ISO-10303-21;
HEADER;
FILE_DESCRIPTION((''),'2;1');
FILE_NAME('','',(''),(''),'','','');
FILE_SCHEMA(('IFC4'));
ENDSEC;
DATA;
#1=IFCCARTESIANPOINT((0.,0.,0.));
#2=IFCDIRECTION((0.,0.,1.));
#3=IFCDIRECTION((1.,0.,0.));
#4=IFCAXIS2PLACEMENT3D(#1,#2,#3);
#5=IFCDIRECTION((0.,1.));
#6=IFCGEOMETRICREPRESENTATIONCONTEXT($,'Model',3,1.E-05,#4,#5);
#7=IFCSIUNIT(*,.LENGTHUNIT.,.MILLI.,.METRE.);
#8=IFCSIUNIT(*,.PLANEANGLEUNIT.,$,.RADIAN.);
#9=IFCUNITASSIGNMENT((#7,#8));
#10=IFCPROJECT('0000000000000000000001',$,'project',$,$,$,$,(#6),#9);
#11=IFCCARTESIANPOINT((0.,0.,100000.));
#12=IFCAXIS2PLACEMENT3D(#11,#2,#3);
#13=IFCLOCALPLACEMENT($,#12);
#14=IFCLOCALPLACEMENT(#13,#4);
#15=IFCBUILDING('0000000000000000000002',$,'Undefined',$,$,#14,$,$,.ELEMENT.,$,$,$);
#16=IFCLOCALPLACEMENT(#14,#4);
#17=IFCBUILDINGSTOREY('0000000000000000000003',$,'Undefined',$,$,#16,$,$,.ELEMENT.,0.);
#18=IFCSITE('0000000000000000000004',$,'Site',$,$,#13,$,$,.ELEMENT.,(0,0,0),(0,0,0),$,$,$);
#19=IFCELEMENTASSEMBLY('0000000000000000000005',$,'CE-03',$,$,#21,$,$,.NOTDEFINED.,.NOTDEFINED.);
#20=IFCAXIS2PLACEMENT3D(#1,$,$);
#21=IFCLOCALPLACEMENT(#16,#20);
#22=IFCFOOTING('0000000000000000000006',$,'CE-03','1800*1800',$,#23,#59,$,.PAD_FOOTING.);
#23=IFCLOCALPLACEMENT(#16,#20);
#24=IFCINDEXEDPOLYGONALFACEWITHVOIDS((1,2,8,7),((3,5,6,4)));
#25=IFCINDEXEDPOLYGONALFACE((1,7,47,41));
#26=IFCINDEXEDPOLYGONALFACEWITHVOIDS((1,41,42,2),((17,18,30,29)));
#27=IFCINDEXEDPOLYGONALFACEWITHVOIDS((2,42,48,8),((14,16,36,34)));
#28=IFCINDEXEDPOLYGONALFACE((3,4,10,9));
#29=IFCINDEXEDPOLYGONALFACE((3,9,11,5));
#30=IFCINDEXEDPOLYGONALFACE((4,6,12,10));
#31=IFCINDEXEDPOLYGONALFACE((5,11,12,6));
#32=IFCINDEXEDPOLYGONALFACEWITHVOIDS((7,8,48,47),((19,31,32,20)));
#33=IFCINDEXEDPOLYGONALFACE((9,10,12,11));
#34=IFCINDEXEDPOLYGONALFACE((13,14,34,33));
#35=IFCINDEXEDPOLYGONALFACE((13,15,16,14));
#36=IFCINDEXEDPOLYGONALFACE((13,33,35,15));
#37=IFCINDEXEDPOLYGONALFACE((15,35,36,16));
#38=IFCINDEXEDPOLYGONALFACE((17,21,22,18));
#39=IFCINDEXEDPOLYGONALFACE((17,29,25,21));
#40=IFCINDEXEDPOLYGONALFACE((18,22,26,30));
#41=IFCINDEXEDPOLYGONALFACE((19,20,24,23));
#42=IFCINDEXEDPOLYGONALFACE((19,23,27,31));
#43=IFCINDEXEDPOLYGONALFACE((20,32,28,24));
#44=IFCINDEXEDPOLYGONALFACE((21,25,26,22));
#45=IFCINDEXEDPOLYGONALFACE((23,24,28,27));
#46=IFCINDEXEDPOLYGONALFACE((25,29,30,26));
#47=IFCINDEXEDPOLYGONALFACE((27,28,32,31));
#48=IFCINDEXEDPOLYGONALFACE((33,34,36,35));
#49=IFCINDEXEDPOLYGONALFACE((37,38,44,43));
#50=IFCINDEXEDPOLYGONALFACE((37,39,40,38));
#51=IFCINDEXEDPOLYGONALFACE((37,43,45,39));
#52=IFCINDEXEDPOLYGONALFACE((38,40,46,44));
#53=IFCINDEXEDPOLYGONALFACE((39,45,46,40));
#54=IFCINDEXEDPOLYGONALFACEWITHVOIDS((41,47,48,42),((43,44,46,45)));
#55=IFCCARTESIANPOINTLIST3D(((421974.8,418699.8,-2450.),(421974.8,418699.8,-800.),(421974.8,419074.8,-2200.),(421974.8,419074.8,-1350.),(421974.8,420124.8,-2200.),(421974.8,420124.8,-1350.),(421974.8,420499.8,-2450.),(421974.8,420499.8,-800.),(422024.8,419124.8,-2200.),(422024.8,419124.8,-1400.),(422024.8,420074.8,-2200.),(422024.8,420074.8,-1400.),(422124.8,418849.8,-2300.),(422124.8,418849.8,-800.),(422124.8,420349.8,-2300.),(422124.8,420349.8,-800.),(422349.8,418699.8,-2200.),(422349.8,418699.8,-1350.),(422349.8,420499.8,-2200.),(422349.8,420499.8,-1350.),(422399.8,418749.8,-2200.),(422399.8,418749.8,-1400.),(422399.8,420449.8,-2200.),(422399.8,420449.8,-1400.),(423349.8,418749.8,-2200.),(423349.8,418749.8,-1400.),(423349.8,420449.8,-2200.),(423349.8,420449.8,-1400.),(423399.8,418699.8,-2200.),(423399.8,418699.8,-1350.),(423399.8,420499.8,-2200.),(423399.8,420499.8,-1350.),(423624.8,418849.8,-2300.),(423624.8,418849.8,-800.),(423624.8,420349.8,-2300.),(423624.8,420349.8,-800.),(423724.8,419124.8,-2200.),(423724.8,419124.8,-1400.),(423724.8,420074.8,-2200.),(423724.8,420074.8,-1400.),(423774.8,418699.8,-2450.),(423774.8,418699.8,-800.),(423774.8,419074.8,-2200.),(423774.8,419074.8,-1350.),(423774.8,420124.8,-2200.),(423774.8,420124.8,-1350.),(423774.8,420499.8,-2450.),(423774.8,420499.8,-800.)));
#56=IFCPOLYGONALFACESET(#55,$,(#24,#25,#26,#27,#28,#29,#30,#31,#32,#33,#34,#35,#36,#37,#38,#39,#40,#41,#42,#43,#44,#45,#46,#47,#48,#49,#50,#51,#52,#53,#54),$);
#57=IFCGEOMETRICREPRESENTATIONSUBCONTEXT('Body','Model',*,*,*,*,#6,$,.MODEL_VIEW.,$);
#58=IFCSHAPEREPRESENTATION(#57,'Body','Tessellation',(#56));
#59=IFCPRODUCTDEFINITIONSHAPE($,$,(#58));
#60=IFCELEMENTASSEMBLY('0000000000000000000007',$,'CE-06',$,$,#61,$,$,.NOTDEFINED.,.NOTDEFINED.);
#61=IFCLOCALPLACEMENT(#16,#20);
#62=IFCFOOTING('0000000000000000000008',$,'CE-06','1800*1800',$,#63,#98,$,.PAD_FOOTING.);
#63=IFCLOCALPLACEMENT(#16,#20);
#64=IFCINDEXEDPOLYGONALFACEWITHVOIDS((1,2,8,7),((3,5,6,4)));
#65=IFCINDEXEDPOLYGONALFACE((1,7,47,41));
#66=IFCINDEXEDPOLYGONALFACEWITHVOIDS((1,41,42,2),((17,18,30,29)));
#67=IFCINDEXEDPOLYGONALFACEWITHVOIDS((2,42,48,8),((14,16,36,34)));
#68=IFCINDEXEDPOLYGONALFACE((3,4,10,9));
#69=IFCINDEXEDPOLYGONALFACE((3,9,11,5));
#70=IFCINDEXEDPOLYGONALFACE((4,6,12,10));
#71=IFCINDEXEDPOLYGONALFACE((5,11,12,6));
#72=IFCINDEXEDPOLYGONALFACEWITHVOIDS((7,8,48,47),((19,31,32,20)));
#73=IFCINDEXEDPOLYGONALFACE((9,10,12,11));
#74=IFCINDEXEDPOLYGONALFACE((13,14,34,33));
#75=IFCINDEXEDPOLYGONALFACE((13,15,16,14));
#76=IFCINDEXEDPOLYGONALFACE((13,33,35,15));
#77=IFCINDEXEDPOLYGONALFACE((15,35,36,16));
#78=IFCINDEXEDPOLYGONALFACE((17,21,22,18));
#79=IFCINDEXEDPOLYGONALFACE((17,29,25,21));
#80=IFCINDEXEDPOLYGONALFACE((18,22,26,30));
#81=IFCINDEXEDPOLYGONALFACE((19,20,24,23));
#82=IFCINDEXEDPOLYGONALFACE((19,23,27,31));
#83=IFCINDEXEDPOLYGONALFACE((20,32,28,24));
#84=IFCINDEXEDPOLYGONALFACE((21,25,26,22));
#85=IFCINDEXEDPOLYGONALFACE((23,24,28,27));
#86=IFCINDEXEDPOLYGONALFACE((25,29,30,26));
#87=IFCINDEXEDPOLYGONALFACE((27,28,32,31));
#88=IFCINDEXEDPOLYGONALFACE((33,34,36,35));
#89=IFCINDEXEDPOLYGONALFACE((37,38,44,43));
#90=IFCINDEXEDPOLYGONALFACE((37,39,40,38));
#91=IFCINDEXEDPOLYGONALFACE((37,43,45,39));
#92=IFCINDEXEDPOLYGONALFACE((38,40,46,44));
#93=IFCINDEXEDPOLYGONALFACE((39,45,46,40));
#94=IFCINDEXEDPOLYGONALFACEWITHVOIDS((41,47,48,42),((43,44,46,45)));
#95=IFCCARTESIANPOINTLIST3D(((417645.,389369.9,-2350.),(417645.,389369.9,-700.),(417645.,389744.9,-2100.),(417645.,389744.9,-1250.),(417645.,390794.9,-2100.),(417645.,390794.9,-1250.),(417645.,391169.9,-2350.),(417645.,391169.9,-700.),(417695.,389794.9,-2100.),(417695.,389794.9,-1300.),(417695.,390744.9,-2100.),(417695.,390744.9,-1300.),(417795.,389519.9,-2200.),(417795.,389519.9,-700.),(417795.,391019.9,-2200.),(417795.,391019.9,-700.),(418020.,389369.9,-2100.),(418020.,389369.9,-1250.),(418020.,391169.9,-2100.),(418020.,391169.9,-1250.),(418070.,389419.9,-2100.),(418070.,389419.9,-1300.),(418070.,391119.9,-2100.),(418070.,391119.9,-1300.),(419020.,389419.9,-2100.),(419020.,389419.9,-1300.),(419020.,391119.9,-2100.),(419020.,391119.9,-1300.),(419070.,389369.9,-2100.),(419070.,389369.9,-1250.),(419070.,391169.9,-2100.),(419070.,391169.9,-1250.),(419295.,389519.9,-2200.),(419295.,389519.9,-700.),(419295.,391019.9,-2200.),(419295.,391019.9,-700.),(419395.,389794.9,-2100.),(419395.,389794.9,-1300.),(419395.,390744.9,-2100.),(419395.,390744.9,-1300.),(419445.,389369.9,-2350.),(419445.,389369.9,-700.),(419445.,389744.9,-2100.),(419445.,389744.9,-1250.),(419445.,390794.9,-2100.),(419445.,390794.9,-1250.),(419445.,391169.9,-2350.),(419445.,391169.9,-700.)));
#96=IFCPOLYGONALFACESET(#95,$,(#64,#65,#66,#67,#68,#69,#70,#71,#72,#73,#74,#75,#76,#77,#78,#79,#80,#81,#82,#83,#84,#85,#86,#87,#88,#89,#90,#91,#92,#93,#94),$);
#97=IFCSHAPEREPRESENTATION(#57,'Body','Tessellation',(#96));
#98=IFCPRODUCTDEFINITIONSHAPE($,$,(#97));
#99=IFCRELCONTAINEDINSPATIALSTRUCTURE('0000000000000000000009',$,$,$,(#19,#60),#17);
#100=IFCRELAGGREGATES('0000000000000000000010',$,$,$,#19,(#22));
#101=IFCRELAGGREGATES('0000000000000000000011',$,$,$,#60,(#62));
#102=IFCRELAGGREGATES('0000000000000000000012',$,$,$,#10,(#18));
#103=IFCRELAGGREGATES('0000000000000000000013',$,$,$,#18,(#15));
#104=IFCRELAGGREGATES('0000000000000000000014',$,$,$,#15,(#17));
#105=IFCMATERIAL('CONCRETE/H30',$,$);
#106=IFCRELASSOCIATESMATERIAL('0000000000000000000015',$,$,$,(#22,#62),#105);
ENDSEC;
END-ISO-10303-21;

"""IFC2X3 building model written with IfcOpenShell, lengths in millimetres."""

from ifc_helpers import new_model, si_unit, direction, frame, origin_with_axes, origin_2d_with_axis, place, context, subcontext, project, spatial, polyline, rectangle, outline, extrude, boolean, material, element, aggregate, save


model = new_model("IFC2X3")

# Units and contexts
model_context = context("Model", 3, precision=1e-05, world=origin_with_axes(), true_north=direction((0.0, 1.0)))
body_context = subcontext(model_context, "Body", "Model", "MODEL_VIEW")
ifc_project = project(units=[si_unit("LENGTHUNIT", "METRE", prefix="MILLI"), si_unit("PLANEANGLEUNIT", "RADIAN")], contexts=[model_context])

# Site, building, storey
site_placement = place(None, frame((0.0, 0.0, 100000.0), z_axis=(0.0, 0.0, 1.0), x_axis=(1.0, 0.0, 0.0)))
site = spatial("IfcSite", under=ifc_project, at=site_placement, Name="Site", CompositionType="ELEMENT", RefLatitude=(0, 0, 0), RefLongitude=(0, 0, 0))
building_placement = place(site_placement, origin_with_axes())
building = spatial("IfcBuilding", under=site, at=building_placement, Name="Undefined", CompositionType="ELEMENT")
storey_placement = place(building_placement, origin_with_axes())
storey = spatial("IfcBuildingStorey", under=building, at=storey_placement, Name="Undefined", CompositionType="ELEMENT", Elevation=0.0)

# Element assemblies, footings
ifc_material_1 = material(Name="CONCRETE/H30")
assembly_1_placement = place(storey_placement, origin_with_axes())
assembly_1 = element("IfcElementAssembly", 1, at=assembly_1_placement, inside=storey, Name="CE-03", AssemblyPlace="NOTDEFINED", PredefinedType="NOTDEFINED")
footing_1_placement = place(assembly_1_placement, frame((422874.8, 419599.8, -2450.0), z_axis=(0.0, 1.0, 0.0), x_axis=(0.0, 0.0, 1.0)))
solid_1 = boolean("DIFFERENCE", boolean("DIFFERENCE", boolean("DIFFERENCE", extrude(outline(polyline([(0.0, 0.0), (1050.0, 0.0), (1050.0, 850.0), (0.0, 850.0), (0.0, 0.0)])), frame((1100.0, 900.0, -525.0), z_axis=(0.0, -1.0, 0.0), x_axis=(0.0, 0.0, 1.0)), (0.0, 0.0, 1.0), 50.0), extrude(outline(polyline([(0.0, 0.0), (70.7, 0.0), (70.7, 850.0), (0.0, 850.0), (0.0, 0.0)])), frame((1100.0, 708.6, -616.4), z_axis=(0.0, 0.707107, 0.707107), x_axis=(0.0, 0.707107, -0.707107)), (0.0, 0.0, 1.0), 200.0)), extrude(outline(polyline([(0.0, 0.0), (70.7, 0.0), (70.7, 850.0), (0.0, 850.0), (0.0, 0.0)])), frame((1100.0, 758.6, 666.4), z_axis=(0.0, 0.707107, -0.707107), x_axis=(0.0, -0.707107, -0.707107)), (0.0, 0.0, 1.0), 200.0)), extrude(outline(polyline([(0.0, 0.0), (70.7, 0.0), (70.7, 1050.0), (0.0, 1050.0), (0.0, 0.0)])), frame((1050.0, 850.0, -525.0), z_axis=(0.707107, -0.707107, 0.0), x_axis=(0.707107, 0.707107, 0.0)), (0.0, 0.0, 1.0), 200.0))
solid_2 = boolean("DIFFERENCE", boolean("DIFFERENCE", boolean("DIFFERENCE", extrude(outline(polyline([(0.0, 0.0), (1050.0, 0.0), (1050.0, 850.0), (0.0, 850.0), (0.0, 0.0)])), frame((1100.0, -525.0, -900.0), z_axis=(0.0, 0.0, 1.0), x_axis=(0.0, 1.0, 0.0)), (0.0, 0.0, 1.0), 50.0), extrude(outline(polyline([(0.0, 0.0), (70.7, 0.0), (70.7, 850.0), (0.0, 850.0), (0.0, 0.0)])), frame((1100.0, -616.4, -708.6), z_axis=(0.0, 0.707107, -0.707107), x_axis=(0.0, -0.707107, -0.707107)), (0.0, 0.0, 1.0), 200.0)), extrude(outline(polyline([(0.0, 0.0), (70.7, 0.0), (70.7, 850.0), (0.0, 850.0), (0.0, 0.0)])), frame((1100.0, 666.4, -758.6), z_axis=(0.0, -0.707107, -0.707107), x_axis=(0.0, -0.707107, 0.707107)), (0.0, 0.0, 1.0), 200.0)), extrude(outline(polyline([(0.0, 0.0), (70.7, 0.0), (70.7, 1050.0), (0.0, 1050.0), (0.0, 0.0)])), frame((1050.0, -525.0, -850.0), z_axis=(0.707107, 0.0, 0.707107), x_axis=(0.707107, 0.0, -0.707107)), (0.0, 0.0, 1.0), 200.0))
solid_3 = boolean("DIFFERENCE", boolean("DIFFERENCE", boolean("DIFFERENCE", extrude(outline(polyline([(0.0, 0.0), (1050.0, 0.0), (1050.0, 850.0), (0.0, 850.0), (0.0, 0.0)])), frame((1100.0, -525.0, 850.0), z_axis=(0.0, 0.0, 1.0), x_axis=(0.0, 1.0, 0.0)), (0.0, 0.0, 1.0), 50.0), extrude(outline(polyline([(0.0, 0.0), (70.7, 0.0), (70.7, 850.0), (0.0, 850.0), (0.0, 0.0)])), frame((1100.0, -475.0, 850.0), z_axis=(0.0, -0.707107, -0.707107), x_axis=(0.0, -0.707107, 0.707107)), (0.0, 0.0, 1.0), 200.0)), extrude(outline(polyline([(0.0, 0.0), (70.7, 0.0), (70.7, 850.0), (0.0, 850.0), (0.0, 0.0)])), frame((1100.0, 525.0, 900.0), z_axis=(0.0, 0.707107, -0.707107), x_axis=(0.0, -0.707107, -0.707107)), (0.0, 0.0, 1.0), 200.0)), extrude(outline(polyline([(0.0, 0.0), (70.7, 0.0), (70.7, 1050.0), (0.0, 1050.0), (0.0, 0.0)])), frame((1191.4, -525.0, 708.6), z_axis=(-0.707107, 0.0, 0.707107), x_axis=(0.707107, 0.0, 0.707107)), (0.0, 0.0, 1.0), 200.0))
solid_4 = boolean("DIFFERENCE", boolean("DIFFERENCE", boolean("DIFFERENCE", extrude(outline(polyline([(0.0, 0.0), (1050.0, 0.0), (1050.0, 850.0), (0.0, 850.0), (0.0, 0.0)])), frame((1100.0, -850.0, -525.0), z_axis=(0.0, -1.0, 0.0), x_axis=(0.0, 0.0, 1.0)), (0.0, 0.0, 1.0), 50.0), extrude(outline(polyline([(0.0, 0.0), (70.7, 0.0), (70.7, 850.0), (0.0, 850.0), (0.0, 0.0)])), frame((1100.0, -850.0, -475.0), z_axis=(0.0, 0.707107, -0.707107), x_axis=(0.0, -0.707107, -0.707107)), (0.0, 0.0, 1.0), 200.0)), extrude(outline(polyline([(0.0, 0.0), (70.7, 0.0), (70.7, 850.0), (0.0, 850.0), (0.0, 0.0)])), frame((1100.0, -900.0, 525.0), z_axis=(0.0, 0.707107, 0.707107), x_axis=(0.0, 0.707107, -0.707107)), (0.0, 0.0, 1.0), 200.0)), extrude(outline(polyline([(0.0, 0.0), (70.7, 0.0), (70.7, 1050.0), (0.0, 1050.0), (0.0, 0.0)])), frame((1191.4, -708.6, -525.0), z_axis=(-0.707107, -0.707107, 0.0), x_axis=(0.707107, -0.707107, 0.0)), (0.0, 0.0, 1.0), 200.0))
footing_1 = element("IfcFooting", 2, at=footing_1_placement, material=ifc_material_1, Name="CE-03", Description="1800*1800", PredefinedType="PAD_FOOTING", context=body_context, shape_type="CSG", body=[
    boolean("DIFFERENCE", boolean("DIFFERENCE", boolean("DIFFERENCE", boolean("DIFFERENCE", boolean("DIFFERENCE", extrude(rectangle(XDim=1800.0, YDim=1800.0, at=origin_2d_with_axis()), frame((1650.0, 0.0, 0.0), z_axis=(-1.0, 0.0, 0.0), x_axis=(0.0, -1.0, 0.0)), (0.0, 0.0, 1.0), 1650.0), solid_1), solid_2), solid_3), solid_4), extrude(rectangle(XDim=1500.0, YDim=1500.0, at=origin_2d_with_axis()), frame((1650.0, 0.0, 0.0), z_axis=(-1.0, 0.0, 0.0), x_axis=(0.0, -1.0, 0.0)), (0.0, 0.0, 1.0), 1500.0)),
])
aggregate(assembly_1, [footing_1])
assembly_2_placement = place(storey_placement, origin_with_axes())
assembly_2 = element("IfcElementAssembly", 3, at=assembly_2_placement, inside=storey, Name="CE-06", AssemblyPlace="NOTDEFINED", PredefinedType="NOTDEFINED")
footing_2_placement = place(assembly_2_placement, frame((418545.0, 390269.9, -2350.0), z_axis=(0.0, 1.0, 0.0), x_axis=(0.0, 0.0, 1.0)))
solid_5 = boolean("DIFFERENCE", boolean("DIFFERENCE", boolean("DIFFERENCE", extrude(outline(polyline([(0.0, 0.0), (1050.0, 0.0), (1050.0, 850.0), (0.0, 850.0), (0.0, 0.0)])), frame((1100.0, 900.0, -525.0), z_axis=(0.0, -1.0, 0.0), x_axis=(0.0, 0.0, 1.0)), (0.0, 0.0, 1.0), 50.0), extrude(outline(polyline([(0.0, 0.0), (70.7, 0.0), (70.7, 850.0), (0.0, 850.0), (0.0, 0.0)])), frame((1100.0, 708.6, -616.4), z_axis=(0.0, 0.707107, 0.707107), x_axis=(0.0, 0.707107, -0.707107)), (0.0, 0.0, 1.0), 200.0)), extrude(outline(polyline([(0.0, 0.0), (70.7, 0.0), (70.7, 850.0), (0.0, 850.0), (0.0, 0.0)])), frame((1100.0, 758.6, 666.4), z_axis=(0.0, 0.707107, -0.707107), x_axis=(0.0, -0.707107, -0.707107)), (0.0, 0.0, 1.0), 200.0)), extrude(outline(polyline([(0.0, 0.0), (70.7, 0.0), (70.7, 1050.0), (0.0, 1050.0), (0.0, 0.0)])), frame((1050.0, 850.0, -525.0), z_axis=(0.707107, -0.707107, 0.0), x_axis=(0.707107, 0.707107, 0.0)), (0.0, 0.0, 1.0), 200.0))
solid_6 = boolean("DIFFERENCE", boolean("DIFFERENCE", boolean("DIFFERENCE", extrude(outline(polyline([(0.0, 0.0), (1050.0, 0.0), (1050.0, 850.0), (0.0, 850.0), (0.0, 0.0)])), frame((1100.0, -525.0, -900.0), z_axis=(0.0, 0.0, 1.0), x_axis=(0.0, 1.0, 0.0)), (0.0, 0.0, 1.0), 50.0), extrude(outline(polyline([(0.0, 0.0), (70.7, 0.0), (70.7, 850.0), (0.0, 850.0), (0.0, 0.0)])), frame((1100.0, -616.4, -708.6), z_axis=(0.0, 0.707107, -0.707107), x_axis=(0.0, -0.707107, -0.707107)), (0.0, 0.0, 1.0), 200.0)), extrude(outline(polyline([(0.0, 0.0), (70.7, 0.0), (70.7, 850.0), (0.0, 850.0), (0.0, 0.0)])), frame((1100.0, 666.4, -758.6), z_axis=(0.0, -0.707107, -0.707107), x_axis=(0.0, -0.707107, 0.707107)), (0.0, 0.0, 1.0), 200.0)), extrude(outline(polyline([(0.0, 0.0), (70.7, 0.0), (70.7, 1050.0), (0.0, 1050.0), (0.0, 0.0)])), frame((1050.0, -525.0, -850.0), z_axis=(0.707107, 0.0, 0.707107), x_axis=(0.707107, 0.0, -0.707107)), (0.0, 0.0, 1.0), 200.0))
solid_7 = boolean("DIFFERENCE", boolean("DIFFERENCE", boolean("DIFFERENCE", extrude(outline(polyline([(0.0, 0.0), (1050.0, 0.0), (1050.0, 850.0), (0.0, 850.0), (0.0, 0.0)])), frame((1100.0, -525.0, 850.0), z_axis=(0.0, 0.0, 1.0), x_axis=(0.0, 1.0, 0.0)), (0.0, 0.0, 1.0), 50.0), extrude(outline(polyline([(0.0, 0.0), (70.7, 0.0), (70.7, 850.0), (0.0, 850.0), (0.0, 0.0)])), frame((1100.0, -475.0, 850.0), z_axis=(0.0, -0.707107, -0.707107), x_axis=(0.0, -0.707107, 0.707107)), (0.0, 0.0, 1.0), 200.0)), extrude(outline(polyline([(0.0, 0.0), (70.7, 0.0), (70.7, 850.0), (0.0, 850.0), (0.0, 0.0)])), frame((1100.0, 525.0, 900.0), z_axis=(0.0, 0.707107, -0.707107), x_axis=(0.0, -0.707107, -0.707107)), (0.0, 0.0, 1.0), 200.0)), extrude(outline(polyline([(0.0, 0.0), (70.7, 0.0), (70.7, 1050.0), (0.0, 1050.0), (0.0, 0.0)])), frame((1191.4, -525.0, 708.6), z_axis=(-0.707107, 0.0, 0.707107), x_axis=(0.707107, 0.0, 0.707107)), (0.0, 0.0, 1.0), 200.0))
solid_8 = boolean("DIFFERENCE", boolean("DIFFERENCE", boolean("DIFFERENCE", extrude(outline(polyline([(0.0, 0.0), (1050.0, 0.0), (1050.0, 850.0), (0.0, 850.0), (0.0, 0.0)])), frame((1100.0, -850.0, -525.0), z_axis=(0.0, -1.0, 0.0), x_axis=(0.0, 0.0, 1.0)), (0.0, 0.0, 1.0), 50.0), extrude(outline(polyline([(0.0, 0.0), (70.7, 0.0), (70.7, 850.0), (0.0, 850.0), (0.0, 0.0)])), frame((1100.0, -850.0, -475.0), z_axis=(0.0, 0.707107, -0.707107), x_axis=(0.0, -0.707107, -0.707107)), (0.0, 0.0, 1.0), 200.0)), extrude(outline(polyline([(0.0, 0.0), (70.7, 0.0), (70.7, 850.0), (0.0, 850.0), (0.0, 0.0)])), frame((1100.0, -900.0, 525.0), z_axis=(0.0, 0.707107, 0.707107), x_axis=(0.0, 0.707107, -0.707107)), (0.0, 0.0, 1.0), 200.0)), extrude(outline(polyline([(0.0, 0.0), (70.7, 0.0), (70.7, 1050.0), (0.0, 1050.0), (0.0, 0.0)])), frame((1191.4, -708.6, -525.0), z_axis=(-0.707107, -0.707107, 0.0), x_axis=(0.707107, -0.707107, 0.0)), (0.0, 0.0, 1.0), 200.0))
footing_2 = element("IfcFooting", 4, at=footing_2_placement, material=ifc_material_1, Name="CE-06", Description="1800*1800", PredefinedType="PAD_FOOTING", context=body_context, shape_type="CSG", body=[
    boolean("DIFFERENCE", boolean("DIFFERENCE", boolean("DIFFERENCE", boolean("DIFFERENCE", boolean("DIFFERENCE", extrude(rectangle(XDim=1800.0, YDim=1800.0, at=origin_2d_with_axis()), frame((1650.0, 0.0, 0.0), z_axis=(-1.0, 0.0, 0.0), x_axis=(0.0, -1.0, 0.0)), (0.0, 0.0, 1.0), 1650.0), solid_5), solid_6), solid_7), solid_8), extrude(rectangle(XDim=1500.0, YDim=1500.0, at=origin_2d_with_axis()), frame((1650.0, 0.0, 0.0), z_axis=(-1.0, 0.0, 0.0), x_axis=(0.0, -1.0, 0.0)), (0.0, 0.0, 1.0), 1500.0)),
])
aggregate(assembly_2, [footing_2])

save(model, "model.ifc")
